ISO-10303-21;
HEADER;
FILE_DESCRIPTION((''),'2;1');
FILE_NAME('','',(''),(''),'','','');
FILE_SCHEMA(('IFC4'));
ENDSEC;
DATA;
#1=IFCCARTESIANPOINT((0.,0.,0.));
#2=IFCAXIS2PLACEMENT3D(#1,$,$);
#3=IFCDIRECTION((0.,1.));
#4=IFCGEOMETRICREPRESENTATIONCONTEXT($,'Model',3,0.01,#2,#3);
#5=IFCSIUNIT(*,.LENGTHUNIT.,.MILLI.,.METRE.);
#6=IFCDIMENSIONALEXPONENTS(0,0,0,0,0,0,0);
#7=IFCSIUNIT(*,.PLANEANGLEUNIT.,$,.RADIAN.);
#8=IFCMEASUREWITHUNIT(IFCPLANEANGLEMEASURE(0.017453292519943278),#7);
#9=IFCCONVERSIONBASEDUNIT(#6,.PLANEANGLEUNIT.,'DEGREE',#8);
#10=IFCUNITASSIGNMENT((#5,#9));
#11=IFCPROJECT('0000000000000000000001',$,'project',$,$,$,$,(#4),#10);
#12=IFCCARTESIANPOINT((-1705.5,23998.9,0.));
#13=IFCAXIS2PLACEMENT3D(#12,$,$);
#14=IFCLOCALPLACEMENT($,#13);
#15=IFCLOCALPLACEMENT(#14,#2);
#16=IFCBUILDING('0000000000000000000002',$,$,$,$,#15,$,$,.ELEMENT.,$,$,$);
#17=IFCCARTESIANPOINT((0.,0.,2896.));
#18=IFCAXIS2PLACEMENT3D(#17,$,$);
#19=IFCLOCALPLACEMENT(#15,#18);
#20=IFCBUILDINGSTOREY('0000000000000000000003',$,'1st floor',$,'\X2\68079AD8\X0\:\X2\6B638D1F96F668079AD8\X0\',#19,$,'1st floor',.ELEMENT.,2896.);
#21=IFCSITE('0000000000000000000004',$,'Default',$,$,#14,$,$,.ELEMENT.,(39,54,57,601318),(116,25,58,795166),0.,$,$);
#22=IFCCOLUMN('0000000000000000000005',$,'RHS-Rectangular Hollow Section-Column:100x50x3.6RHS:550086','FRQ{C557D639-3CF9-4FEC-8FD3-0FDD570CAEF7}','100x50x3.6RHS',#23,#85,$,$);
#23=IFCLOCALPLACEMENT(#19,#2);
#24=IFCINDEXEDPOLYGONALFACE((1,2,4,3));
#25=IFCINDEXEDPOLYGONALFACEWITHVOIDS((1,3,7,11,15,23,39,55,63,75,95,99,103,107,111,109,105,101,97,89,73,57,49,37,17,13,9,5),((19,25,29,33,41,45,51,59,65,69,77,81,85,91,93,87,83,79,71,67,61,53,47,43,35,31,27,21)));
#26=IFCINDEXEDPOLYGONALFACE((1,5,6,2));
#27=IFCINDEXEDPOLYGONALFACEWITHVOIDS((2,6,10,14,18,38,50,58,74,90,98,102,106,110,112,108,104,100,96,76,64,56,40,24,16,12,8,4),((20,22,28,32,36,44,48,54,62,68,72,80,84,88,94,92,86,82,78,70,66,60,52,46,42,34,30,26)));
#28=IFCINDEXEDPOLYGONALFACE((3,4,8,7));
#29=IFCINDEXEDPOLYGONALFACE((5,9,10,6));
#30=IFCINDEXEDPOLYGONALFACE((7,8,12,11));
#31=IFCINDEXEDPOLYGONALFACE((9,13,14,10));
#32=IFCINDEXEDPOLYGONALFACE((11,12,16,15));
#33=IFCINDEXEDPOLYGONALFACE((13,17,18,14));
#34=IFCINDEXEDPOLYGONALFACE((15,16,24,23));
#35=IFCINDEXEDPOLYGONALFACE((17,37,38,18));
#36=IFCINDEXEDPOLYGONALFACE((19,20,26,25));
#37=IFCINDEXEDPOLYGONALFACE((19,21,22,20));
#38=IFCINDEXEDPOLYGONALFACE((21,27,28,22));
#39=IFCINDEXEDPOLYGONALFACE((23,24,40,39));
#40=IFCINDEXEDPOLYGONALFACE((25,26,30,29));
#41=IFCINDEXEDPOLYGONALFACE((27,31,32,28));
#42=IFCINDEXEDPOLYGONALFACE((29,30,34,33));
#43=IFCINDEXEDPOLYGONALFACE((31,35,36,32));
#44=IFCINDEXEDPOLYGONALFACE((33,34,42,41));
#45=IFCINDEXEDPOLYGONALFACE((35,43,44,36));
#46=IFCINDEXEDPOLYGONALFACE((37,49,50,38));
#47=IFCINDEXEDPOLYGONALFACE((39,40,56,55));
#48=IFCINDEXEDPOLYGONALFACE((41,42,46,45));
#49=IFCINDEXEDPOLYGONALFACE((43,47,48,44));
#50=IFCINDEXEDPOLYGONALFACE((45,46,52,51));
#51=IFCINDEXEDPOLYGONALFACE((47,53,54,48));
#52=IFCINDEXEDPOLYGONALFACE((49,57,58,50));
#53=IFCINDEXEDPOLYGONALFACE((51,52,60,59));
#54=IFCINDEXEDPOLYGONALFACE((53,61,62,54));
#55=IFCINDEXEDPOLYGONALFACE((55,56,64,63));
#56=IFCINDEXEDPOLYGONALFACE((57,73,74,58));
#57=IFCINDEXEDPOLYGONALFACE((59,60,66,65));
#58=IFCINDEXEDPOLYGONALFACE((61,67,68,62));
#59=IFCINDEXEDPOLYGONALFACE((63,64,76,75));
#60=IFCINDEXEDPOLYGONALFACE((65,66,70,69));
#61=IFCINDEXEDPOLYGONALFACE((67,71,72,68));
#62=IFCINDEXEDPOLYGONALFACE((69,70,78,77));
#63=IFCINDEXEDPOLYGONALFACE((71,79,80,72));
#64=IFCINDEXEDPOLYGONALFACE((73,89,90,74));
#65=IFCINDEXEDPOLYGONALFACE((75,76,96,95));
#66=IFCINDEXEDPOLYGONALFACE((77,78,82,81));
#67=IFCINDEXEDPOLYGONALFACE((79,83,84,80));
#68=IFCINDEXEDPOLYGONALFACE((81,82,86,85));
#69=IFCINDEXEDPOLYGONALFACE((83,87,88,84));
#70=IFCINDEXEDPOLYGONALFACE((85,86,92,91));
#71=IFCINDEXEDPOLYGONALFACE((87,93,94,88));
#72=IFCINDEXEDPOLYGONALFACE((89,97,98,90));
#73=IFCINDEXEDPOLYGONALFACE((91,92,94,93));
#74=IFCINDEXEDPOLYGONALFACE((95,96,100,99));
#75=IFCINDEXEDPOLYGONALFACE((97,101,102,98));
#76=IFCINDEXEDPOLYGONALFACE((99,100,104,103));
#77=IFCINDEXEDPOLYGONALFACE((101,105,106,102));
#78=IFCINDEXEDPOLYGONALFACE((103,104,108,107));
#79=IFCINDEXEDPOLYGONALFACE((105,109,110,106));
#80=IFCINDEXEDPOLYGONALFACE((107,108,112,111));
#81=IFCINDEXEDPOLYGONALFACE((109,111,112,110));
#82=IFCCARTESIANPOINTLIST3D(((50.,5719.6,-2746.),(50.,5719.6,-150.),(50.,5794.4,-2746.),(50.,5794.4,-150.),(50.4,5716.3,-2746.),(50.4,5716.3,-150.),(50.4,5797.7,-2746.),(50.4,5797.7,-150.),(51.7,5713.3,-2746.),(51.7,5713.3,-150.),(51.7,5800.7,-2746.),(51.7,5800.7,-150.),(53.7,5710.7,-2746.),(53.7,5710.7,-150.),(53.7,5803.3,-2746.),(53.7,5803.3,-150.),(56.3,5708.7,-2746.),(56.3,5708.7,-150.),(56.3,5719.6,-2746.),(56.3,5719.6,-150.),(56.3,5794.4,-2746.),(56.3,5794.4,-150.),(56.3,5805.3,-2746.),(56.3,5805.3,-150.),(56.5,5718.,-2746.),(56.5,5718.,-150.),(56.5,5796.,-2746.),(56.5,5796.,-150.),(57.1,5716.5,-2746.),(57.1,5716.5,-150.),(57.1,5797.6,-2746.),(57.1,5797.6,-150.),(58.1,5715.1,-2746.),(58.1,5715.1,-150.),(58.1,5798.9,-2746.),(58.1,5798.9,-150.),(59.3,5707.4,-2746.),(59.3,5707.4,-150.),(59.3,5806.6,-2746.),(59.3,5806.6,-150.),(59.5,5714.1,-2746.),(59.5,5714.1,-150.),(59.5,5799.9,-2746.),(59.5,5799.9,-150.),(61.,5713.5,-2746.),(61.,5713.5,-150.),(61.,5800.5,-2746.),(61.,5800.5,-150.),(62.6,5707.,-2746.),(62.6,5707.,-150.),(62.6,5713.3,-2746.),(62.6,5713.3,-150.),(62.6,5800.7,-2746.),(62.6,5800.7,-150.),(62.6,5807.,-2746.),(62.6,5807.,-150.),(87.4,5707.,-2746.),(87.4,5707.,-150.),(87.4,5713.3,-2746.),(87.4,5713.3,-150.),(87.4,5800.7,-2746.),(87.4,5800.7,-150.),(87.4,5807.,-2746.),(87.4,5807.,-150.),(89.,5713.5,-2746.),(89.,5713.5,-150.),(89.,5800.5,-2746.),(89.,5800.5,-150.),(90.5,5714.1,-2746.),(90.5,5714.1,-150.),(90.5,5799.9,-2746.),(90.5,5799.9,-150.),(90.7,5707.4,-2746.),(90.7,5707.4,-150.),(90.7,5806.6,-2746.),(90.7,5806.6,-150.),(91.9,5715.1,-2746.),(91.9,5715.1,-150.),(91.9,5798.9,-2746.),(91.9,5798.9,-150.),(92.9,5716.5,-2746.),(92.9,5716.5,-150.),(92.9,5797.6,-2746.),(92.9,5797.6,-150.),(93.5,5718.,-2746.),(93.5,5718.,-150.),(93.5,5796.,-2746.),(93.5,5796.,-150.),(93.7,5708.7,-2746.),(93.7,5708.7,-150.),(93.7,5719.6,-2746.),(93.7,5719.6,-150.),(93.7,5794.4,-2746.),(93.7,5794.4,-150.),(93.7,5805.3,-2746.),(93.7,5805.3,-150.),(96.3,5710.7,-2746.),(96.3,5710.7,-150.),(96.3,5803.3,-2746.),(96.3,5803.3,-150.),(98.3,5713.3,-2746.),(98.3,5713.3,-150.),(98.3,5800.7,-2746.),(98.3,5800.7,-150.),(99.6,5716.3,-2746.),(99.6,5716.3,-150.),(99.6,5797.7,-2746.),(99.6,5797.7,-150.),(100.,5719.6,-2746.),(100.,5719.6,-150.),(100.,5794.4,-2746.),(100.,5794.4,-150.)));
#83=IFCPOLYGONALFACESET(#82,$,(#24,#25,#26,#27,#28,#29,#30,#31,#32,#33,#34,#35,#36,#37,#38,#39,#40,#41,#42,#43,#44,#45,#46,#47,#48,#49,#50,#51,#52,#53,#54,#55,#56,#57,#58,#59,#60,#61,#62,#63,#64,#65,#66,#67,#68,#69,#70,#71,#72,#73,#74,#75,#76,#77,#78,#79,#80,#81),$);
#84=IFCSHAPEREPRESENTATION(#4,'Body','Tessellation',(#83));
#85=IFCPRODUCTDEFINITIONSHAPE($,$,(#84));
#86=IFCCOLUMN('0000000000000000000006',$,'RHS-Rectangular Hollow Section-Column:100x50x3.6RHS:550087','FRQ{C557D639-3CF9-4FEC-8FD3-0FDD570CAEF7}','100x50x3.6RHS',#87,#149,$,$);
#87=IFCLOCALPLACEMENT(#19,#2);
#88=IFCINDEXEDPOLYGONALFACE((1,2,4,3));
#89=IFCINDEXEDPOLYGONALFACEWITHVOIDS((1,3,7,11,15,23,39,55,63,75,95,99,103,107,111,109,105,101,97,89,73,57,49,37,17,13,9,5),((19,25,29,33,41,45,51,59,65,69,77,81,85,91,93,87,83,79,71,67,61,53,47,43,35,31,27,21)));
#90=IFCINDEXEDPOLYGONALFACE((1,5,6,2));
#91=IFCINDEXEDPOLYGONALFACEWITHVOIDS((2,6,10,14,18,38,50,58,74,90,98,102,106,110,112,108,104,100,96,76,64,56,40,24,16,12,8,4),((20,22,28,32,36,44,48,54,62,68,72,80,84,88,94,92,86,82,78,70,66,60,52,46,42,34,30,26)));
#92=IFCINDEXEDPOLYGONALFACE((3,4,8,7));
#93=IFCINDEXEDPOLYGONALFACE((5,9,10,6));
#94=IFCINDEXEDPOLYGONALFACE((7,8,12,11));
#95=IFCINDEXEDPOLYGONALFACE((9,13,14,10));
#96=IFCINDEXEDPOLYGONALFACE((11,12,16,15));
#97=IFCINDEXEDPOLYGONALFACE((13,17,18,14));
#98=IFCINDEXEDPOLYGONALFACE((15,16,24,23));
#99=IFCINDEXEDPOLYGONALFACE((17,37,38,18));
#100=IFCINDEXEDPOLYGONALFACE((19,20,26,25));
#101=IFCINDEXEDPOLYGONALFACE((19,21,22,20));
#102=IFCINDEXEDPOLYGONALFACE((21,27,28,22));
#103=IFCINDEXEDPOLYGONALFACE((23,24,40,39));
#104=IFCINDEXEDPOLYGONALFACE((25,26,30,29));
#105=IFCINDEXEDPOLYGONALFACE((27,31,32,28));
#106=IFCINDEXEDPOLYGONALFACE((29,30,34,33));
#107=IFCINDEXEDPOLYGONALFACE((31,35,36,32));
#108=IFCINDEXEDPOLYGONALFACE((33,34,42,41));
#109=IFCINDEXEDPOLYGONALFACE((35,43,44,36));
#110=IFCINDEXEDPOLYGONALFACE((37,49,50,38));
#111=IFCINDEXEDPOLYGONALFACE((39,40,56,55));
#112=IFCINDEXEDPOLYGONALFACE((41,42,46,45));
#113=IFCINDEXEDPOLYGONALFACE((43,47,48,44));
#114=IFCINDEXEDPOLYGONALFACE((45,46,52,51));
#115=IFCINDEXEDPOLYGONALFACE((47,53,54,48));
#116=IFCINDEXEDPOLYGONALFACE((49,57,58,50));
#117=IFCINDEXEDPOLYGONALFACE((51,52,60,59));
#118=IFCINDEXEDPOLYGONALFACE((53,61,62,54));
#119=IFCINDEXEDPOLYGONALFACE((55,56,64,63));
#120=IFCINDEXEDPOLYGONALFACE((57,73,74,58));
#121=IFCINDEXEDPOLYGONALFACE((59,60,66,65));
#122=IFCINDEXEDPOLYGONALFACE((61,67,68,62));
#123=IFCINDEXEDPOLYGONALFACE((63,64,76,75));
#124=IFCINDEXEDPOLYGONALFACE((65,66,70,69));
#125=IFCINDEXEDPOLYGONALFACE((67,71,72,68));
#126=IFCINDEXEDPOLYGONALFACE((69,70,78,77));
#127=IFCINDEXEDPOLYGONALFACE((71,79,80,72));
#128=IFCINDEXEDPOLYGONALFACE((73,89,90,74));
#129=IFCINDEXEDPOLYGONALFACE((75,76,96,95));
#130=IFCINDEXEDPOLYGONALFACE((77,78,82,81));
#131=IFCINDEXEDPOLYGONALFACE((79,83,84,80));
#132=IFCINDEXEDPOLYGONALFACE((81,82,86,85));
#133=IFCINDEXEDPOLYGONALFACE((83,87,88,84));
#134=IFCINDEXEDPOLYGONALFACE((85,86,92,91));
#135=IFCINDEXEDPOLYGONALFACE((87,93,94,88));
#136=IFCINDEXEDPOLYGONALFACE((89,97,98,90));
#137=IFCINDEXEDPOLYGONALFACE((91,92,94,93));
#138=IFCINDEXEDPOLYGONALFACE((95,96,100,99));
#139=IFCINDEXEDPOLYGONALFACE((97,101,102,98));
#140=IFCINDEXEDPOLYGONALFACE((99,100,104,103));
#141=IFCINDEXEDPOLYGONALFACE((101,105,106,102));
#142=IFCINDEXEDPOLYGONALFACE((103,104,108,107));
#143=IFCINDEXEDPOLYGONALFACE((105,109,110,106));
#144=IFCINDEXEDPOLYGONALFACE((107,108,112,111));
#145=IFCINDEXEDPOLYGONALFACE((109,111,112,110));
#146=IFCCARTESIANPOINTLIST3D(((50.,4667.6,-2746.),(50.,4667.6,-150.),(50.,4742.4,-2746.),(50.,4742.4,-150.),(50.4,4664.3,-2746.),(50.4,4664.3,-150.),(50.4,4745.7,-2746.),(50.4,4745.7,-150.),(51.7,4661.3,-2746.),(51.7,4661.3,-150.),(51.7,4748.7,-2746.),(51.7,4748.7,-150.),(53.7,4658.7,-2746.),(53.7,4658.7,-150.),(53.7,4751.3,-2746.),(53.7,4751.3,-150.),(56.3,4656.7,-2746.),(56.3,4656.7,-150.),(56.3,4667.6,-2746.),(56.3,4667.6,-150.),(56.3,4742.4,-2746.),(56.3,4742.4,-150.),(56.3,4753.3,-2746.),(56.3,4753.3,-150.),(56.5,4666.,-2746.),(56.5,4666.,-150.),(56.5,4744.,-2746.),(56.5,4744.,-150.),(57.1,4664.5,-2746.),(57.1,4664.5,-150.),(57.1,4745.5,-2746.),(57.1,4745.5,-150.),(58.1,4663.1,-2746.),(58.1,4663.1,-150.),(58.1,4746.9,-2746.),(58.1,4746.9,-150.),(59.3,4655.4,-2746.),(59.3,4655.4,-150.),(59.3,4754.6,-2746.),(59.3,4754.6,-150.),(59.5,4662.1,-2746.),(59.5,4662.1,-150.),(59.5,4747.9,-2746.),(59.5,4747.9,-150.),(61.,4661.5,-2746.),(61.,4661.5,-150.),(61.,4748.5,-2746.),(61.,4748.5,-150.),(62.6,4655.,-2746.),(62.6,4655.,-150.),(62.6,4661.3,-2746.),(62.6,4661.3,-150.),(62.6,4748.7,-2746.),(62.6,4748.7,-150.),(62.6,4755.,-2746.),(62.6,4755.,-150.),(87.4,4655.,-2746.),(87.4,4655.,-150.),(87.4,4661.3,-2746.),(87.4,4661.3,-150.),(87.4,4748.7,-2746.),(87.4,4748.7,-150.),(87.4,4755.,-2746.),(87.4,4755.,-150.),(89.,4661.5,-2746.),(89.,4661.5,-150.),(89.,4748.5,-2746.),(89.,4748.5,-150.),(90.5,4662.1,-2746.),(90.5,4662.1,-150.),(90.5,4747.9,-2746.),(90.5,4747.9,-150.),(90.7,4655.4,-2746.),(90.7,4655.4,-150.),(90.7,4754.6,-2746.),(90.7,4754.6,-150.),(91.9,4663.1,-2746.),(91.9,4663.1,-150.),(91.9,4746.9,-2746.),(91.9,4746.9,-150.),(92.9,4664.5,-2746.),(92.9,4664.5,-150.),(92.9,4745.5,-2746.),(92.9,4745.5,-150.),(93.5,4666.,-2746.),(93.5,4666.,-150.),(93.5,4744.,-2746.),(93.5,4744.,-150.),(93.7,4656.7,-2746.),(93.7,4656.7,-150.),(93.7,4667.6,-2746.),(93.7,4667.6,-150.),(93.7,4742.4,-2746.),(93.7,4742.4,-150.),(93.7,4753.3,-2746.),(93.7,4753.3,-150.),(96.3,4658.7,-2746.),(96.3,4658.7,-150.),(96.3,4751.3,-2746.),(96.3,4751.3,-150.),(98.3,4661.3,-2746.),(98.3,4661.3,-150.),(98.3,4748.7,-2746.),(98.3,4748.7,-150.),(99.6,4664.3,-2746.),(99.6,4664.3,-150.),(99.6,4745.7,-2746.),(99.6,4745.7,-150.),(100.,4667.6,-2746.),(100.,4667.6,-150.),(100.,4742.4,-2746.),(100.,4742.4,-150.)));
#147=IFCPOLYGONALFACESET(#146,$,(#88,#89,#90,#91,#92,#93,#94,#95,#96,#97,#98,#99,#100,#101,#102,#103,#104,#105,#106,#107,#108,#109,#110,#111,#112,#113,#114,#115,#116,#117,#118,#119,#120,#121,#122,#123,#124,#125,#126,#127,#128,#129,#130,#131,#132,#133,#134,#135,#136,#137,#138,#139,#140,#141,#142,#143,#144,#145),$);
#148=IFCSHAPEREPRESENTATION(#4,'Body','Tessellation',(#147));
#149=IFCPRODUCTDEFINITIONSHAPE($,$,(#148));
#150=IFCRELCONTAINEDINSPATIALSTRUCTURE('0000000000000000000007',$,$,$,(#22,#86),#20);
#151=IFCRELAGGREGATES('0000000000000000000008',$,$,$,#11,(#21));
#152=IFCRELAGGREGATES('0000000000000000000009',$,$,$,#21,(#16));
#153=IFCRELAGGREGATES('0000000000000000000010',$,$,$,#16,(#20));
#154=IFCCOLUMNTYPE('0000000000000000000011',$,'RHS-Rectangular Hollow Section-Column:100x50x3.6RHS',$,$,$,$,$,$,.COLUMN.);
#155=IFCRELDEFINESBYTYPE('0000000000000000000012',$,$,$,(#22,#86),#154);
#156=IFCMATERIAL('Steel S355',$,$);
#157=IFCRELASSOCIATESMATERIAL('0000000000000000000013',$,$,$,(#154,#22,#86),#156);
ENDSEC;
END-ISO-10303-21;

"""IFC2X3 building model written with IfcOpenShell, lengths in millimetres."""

from ifc_helpers import new_model, entity, si_unit, converted_unit, direction, frame, origin, origin_2d, place, context, project, spatial, hollow_rectangle, extrude, clip, halfspace, material, type_object, element, save


model = new_model("IFC2X3")

# Units and contexts
model_context = context("Model", 3, precision=0.01, world=origin(), true_north=direction((0.0, 1.0)))
ifc_project = project(units=[si_unit("LENGTHUNIT", "METRE", prefix="MILLI"), converted_unit("PLANEANGLEUNIT", "DEGREE", entity("IfcPlaneAngleMeasure", 0.017453292519943278), si_unit("PLANEANGLEUNIT", "RADIAN"), dimensions=[0, 0, 0, 0, 0, 0, 0])], contexts=[model_context])

# Site, building, storey
site_placement = place(None, frame((-1705.5, 23998.9, 0.0)))
site = spatial("IfcSite", under=ifc_project, at=site_placement, Name="Default", CompositionType="ELEMENT", RefLatitude=(39, 54, 57, 601318), RefLongitude=(116, 25, 58, 795166), RefElevation=0.0)
building_placement = place(site_placement, origin())
building = spatial("IfcBuilding", under=site, at=building_placement, CompositionType="ELEMENT")
storey_placement = place(building_placement, frame((0.0, 0.0, 2896.0)))
storey = spatial("IfcBuildingStorey", under=building, at=storey_placement, Name="1st floor", ObjectType="标高:正负零标高", LongName="1st floor", CompositionType="ELEMENT", Elevation=2896.0)

# Columns
ifc_material_1 = material(Name="Steel S355")
column_type = type_object("IfcColumnType", Name="RHS-Rectangular Hollow Section-Column:100x50x3.6RHS", PredefinedType="COLUMN", material=ifc_material_1)
column_1_placement = place(storey_placement, frame((75.0, 5757.0, -150.0), z_axis=(0.0, 0.0, 1.0), x_axis=(-1.0, 0.0, 0.0)))
element("IfcColumn", 1, at=column_1_placement, inside=storey, type_object=column_type, material=ifc_material_1, Name="RHS-Rectangular Hollow Section-Column:100x50x3.6RHS:550086", Description="FRQ{C557D639-3CF9-4FEC-8FD3-0FDD570CAEF7}", ObjectType="100x50x3.6RHS", context=model_context, shape_type="Clipping", body=[
    clip(extrude(hollow_rectangle(XDim=50.0, YDim=100.0, WallThickness=6.3, InnerFilletRadius=6.3, OuterFilletRadius=12.6, at=origin_2d()), origin(), (0.0, 0.0, -1.0), 2651.9), halfspace(frame((75.0, 5757.0, -2596.0), z_axis=(0.0, 0.0, 1.0), x_axis=(-1.0, 0.0, 0.0)), True)),
])
column_2_placement = place(storey_placement, frame((75.0, 4705.0, -150.0), z_axis=(0.0, 0.0, 1.0), x_axis=(-1.0, 0.0, 0.0)))
element("IfcColumn", 2, at=column_2_placement, inside=storey, type_object=column_type, material=ifc_material_1, Name="RHS-Rectangular Hollow Section-Column:100x50x3.6RHS:550087", Description="FRQ{C557D639-3CF9-4FEC-8FD3-0FDD570CAEF7}", ObjectType="100x50x3.6RHS", context=model_context, shape_type="Clipping", body=[
    clip(extrude(hollow_rectangle(XDim=50.0, YDim=100.0, WallThickness=6.3, InnerFilletRadius=6.3, OuterFilletRadius=12.6, at=origin_2d()), origin(), (0.0, 0.0, -1.0), 2651.9), halfspace(frame((75.0, 4705.0, -2596.0), z_axis=(0.0, 0.0, 1.0), x_axis=(-1.0, 0.0, 0.0)), True)),
])

save(model, "model.ifc")
